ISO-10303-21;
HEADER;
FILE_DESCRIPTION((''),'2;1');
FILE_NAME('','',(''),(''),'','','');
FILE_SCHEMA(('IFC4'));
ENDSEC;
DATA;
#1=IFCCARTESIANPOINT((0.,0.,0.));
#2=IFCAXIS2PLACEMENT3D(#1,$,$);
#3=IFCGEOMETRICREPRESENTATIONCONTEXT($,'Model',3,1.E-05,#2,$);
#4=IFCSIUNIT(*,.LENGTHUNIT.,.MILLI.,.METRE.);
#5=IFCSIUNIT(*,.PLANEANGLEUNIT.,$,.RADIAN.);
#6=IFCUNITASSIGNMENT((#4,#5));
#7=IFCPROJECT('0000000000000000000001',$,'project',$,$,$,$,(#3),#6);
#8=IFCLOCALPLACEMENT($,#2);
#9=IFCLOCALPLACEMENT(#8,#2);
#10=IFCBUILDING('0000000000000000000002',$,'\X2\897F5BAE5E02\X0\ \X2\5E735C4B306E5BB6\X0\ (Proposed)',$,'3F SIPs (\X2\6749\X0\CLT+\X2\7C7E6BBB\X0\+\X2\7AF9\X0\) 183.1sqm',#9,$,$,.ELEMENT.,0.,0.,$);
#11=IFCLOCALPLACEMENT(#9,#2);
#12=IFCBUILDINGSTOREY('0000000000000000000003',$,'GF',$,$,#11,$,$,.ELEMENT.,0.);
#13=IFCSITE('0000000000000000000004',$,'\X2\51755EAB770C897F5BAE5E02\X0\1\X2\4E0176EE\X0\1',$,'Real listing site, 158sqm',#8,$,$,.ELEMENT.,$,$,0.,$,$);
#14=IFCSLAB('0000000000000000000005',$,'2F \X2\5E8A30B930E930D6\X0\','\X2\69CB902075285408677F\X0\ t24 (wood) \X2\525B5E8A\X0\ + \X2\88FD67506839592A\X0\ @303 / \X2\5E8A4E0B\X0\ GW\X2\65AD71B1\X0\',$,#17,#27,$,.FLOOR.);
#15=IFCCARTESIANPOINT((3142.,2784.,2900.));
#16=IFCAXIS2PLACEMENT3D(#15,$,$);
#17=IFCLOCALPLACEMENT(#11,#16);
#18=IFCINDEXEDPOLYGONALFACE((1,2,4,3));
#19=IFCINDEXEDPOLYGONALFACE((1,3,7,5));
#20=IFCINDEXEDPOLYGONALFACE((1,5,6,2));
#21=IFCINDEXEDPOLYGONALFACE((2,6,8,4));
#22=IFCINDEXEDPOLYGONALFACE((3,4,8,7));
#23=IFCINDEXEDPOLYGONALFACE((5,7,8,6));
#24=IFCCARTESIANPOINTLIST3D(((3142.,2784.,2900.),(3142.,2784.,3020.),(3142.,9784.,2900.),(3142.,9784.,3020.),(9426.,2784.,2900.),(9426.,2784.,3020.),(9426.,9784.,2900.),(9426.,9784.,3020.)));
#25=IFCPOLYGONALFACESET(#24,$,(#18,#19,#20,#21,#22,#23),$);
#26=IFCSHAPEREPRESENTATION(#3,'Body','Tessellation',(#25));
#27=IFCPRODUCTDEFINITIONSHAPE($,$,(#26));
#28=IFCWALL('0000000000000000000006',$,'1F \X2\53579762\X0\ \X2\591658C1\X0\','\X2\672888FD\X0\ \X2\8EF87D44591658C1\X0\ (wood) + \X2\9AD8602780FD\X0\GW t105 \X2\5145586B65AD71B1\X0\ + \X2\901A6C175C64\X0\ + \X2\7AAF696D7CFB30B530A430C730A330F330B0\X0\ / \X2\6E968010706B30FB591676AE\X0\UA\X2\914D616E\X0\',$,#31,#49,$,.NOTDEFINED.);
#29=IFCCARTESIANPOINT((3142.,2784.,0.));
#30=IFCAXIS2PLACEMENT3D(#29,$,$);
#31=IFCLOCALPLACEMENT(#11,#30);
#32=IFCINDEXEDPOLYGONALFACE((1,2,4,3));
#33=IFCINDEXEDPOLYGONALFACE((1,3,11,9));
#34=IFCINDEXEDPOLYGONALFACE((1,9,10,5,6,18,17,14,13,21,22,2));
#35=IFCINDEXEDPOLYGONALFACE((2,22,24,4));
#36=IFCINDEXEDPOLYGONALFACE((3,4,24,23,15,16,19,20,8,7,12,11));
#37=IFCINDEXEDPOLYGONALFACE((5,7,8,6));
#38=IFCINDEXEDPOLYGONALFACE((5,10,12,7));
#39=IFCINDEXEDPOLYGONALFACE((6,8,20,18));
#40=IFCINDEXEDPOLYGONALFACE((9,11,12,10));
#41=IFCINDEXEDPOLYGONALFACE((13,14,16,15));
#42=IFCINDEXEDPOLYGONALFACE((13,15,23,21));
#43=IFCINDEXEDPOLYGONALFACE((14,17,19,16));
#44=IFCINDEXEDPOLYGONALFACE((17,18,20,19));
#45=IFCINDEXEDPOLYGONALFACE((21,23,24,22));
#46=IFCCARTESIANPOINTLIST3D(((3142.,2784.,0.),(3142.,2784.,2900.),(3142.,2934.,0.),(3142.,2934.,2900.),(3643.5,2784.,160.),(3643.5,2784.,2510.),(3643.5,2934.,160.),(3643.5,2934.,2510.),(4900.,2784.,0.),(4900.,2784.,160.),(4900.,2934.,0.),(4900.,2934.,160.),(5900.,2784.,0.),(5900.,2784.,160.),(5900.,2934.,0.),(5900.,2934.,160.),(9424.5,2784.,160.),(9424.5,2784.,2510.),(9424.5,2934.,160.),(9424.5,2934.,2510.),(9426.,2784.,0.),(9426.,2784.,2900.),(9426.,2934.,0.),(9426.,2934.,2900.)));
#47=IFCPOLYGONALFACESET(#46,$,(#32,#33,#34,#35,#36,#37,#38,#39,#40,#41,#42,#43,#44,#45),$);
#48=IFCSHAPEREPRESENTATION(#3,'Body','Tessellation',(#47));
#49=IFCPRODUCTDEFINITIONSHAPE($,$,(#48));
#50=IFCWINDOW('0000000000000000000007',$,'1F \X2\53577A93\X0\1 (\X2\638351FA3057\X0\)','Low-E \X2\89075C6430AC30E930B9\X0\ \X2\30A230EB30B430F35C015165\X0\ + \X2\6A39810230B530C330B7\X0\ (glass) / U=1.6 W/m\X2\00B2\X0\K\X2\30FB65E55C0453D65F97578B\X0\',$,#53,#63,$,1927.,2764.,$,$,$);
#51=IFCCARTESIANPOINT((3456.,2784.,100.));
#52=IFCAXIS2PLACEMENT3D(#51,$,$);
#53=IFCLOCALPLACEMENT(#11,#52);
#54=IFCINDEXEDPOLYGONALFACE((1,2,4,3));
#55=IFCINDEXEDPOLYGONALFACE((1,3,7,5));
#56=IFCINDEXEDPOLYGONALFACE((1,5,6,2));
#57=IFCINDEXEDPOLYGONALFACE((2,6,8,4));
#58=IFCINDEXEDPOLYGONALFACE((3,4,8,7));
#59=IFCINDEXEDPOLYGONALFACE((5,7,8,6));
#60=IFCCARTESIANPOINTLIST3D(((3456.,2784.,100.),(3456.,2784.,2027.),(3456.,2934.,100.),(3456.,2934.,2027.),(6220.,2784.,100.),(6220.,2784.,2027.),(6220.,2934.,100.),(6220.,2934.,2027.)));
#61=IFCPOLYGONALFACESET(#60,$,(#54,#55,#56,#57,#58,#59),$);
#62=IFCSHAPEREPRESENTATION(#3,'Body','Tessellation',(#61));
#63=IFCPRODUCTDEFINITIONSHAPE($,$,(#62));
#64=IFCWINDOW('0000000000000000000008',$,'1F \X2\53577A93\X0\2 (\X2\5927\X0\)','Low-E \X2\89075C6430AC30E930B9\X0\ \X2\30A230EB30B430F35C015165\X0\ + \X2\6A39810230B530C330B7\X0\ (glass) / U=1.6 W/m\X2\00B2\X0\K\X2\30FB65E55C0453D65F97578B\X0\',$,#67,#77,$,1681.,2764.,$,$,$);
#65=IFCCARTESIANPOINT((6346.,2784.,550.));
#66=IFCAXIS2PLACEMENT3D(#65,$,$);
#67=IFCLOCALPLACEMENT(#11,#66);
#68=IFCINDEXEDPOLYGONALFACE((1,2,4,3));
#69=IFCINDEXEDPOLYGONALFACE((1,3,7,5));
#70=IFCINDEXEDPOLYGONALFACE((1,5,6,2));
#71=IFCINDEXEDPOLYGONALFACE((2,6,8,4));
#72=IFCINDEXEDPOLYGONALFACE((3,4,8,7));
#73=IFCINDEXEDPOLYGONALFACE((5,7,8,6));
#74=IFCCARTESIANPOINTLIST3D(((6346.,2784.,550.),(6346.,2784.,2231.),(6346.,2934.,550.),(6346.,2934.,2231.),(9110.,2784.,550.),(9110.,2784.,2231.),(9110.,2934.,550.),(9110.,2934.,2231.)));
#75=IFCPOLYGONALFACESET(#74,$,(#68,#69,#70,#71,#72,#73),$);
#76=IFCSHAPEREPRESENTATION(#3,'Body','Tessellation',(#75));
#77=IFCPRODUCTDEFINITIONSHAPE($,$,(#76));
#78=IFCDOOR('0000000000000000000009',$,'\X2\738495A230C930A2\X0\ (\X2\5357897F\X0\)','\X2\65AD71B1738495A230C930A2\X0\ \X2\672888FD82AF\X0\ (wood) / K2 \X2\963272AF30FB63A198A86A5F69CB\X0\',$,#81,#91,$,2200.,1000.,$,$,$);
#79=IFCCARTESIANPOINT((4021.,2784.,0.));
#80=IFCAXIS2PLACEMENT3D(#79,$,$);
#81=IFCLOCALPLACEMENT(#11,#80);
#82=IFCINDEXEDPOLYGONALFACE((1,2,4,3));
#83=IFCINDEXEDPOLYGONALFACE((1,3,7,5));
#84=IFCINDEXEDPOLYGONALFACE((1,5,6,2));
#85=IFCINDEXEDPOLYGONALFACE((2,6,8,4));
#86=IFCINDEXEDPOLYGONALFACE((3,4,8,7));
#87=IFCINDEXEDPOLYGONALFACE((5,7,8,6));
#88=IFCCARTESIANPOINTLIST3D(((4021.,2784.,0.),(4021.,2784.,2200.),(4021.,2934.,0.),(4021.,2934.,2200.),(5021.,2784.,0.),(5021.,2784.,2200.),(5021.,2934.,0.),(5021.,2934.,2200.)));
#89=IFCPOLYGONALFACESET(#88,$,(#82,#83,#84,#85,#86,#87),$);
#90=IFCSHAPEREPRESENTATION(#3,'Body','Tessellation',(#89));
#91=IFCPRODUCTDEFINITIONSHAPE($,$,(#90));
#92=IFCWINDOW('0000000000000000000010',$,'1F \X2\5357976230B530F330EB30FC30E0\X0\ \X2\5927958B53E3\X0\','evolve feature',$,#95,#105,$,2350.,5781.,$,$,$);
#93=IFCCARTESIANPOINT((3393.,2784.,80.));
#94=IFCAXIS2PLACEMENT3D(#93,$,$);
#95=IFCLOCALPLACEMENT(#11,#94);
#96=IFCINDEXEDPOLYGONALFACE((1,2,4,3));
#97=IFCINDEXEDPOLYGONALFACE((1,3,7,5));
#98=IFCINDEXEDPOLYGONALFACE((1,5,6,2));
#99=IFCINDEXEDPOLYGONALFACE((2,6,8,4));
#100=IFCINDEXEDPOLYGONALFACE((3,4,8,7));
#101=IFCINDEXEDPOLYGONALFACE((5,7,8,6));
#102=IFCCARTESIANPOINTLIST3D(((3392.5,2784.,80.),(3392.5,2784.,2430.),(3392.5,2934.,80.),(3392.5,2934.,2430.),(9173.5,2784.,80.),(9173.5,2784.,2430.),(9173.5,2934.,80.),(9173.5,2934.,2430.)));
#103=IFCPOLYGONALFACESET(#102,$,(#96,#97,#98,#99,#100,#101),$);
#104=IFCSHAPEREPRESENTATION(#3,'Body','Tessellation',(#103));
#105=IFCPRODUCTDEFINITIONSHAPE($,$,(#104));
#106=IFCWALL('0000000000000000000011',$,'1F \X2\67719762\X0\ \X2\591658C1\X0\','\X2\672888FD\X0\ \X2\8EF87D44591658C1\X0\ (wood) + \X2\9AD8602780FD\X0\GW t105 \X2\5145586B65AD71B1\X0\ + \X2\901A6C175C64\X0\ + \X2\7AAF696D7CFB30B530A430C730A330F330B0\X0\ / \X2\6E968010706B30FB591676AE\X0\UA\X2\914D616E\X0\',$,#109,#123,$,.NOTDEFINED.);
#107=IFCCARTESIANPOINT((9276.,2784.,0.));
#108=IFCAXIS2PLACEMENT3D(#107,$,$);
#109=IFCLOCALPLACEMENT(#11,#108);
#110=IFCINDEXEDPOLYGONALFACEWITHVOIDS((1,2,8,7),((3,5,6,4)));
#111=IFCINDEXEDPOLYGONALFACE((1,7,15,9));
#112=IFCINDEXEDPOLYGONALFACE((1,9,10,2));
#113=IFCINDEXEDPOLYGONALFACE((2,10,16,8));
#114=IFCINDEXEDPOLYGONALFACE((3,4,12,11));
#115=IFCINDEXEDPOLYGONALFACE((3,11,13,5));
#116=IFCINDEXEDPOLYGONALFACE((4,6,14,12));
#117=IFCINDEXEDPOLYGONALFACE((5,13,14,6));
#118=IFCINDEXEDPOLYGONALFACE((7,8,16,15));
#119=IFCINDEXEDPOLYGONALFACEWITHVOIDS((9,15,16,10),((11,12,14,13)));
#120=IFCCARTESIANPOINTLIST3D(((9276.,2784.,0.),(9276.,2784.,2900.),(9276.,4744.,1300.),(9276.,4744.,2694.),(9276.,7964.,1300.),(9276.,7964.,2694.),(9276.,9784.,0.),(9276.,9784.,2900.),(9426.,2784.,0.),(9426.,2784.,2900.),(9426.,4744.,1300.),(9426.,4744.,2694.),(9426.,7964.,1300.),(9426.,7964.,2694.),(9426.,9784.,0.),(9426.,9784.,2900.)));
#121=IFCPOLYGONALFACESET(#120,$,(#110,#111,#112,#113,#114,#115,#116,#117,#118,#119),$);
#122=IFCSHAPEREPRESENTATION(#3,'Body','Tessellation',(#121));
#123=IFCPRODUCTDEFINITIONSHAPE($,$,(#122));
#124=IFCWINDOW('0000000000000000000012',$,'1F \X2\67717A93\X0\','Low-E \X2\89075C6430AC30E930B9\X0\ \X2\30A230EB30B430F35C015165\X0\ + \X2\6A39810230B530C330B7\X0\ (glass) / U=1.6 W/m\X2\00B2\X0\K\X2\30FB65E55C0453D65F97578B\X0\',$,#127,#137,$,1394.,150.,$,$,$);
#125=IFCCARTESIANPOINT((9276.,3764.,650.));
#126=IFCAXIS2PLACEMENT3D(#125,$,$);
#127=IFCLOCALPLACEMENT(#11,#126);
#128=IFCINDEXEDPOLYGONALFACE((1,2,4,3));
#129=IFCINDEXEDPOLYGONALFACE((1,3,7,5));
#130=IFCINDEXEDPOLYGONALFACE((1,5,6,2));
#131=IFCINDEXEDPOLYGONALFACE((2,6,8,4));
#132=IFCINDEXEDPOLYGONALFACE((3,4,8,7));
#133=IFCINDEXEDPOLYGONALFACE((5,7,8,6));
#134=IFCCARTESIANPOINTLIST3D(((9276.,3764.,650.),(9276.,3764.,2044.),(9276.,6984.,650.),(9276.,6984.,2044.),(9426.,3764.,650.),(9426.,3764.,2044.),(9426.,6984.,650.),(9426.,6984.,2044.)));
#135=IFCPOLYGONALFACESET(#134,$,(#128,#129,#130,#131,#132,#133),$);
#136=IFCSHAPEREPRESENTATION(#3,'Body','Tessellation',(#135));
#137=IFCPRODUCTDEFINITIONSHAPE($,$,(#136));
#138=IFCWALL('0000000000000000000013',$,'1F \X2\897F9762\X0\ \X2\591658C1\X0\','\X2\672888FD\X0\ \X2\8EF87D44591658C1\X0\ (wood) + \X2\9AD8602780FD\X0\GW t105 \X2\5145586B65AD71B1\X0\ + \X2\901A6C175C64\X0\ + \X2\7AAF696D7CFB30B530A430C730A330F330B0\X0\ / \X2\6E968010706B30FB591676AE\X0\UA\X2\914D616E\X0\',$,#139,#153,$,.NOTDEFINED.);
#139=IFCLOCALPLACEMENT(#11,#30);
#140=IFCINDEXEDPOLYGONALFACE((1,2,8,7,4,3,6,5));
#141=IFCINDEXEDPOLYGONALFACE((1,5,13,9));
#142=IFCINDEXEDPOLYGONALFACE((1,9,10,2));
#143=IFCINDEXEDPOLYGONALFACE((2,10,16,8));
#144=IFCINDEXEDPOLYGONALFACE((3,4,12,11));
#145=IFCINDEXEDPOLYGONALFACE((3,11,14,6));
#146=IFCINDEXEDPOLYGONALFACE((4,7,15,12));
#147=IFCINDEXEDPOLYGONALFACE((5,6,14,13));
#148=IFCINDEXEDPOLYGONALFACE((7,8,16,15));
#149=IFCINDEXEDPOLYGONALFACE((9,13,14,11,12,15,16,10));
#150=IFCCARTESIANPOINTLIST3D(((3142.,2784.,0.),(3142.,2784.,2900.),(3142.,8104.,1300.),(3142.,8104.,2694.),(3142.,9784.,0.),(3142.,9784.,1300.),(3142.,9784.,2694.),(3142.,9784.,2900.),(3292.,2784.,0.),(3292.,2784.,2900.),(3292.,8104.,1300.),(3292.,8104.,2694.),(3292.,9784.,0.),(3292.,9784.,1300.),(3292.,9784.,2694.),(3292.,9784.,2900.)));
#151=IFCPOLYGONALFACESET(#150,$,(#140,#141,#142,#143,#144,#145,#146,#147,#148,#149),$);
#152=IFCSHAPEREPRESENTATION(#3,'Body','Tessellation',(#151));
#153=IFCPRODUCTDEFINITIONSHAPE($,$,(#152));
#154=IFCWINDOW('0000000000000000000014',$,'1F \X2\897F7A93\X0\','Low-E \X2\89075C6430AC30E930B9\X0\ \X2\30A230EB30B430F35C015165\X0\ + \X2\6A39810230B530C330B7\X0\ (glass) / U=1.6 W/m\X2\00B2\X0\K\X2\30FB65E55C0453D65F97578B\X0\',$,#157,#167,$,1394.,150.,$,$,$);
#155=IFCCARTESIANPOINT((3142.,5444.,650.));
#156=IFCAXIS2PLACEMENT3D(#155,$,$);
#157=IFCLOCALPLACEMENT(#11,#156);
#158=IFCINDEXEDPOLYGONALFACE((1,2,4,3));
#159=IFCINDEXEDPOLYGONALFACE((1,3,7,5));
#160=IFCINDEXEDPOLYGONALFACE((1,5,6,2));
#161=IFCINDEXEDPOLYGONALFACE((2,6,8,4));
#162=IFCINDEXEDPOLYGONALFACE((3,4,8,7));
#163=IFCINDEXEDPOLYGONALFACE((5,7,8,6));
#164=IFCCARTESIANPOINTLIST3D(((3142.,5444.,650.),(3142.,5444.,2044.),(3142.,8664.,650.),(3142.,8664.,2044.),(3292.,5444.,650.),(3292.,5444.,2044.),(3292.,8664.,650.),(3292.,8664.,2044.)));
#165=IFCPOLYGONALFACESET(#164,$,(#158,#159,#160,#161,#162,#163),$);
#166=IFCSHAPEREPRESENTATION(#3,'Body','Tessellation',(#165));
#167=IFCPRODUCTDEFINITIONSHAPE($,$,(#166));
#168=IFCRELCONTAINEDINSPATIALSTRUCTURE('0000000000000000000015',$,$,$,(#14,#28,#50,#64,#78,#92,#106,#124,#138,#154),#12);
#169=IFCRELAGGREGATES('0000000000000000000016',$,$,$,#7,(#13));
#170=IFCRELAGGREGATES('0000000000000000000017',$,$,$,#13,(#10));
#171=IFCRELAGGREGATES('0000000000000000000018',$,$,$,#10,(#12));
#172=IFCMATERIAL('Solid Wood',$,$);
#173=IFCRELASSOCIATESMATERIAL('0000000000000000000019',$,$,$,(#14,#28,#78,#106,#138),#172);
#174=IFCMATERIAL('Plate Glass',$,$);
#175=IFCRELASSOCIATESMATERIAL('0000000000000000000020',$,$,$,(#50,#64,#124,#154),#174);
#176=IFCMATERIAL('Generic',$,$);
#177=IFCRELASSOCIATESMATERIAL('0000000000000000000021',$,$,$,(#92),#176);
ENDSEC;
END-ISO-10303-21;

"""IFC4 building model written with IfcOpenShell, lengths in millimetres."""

from ifc_helpers import new_model, si_unit, frame, frame_2d, origin, place, context, project, spatial, rectangle, extrude, material, element, fill, save


model = new_model("IFC4")

# Units and contexts
model_context = context("Model", 3, precision=1e-05, world=origin())
ifc_project = project(units=[si_unit("LENGTHUNIT", "METRE", prefix="MILLI"), si_unit("PLANEANGLEUNIT", "RADIAN")], contexts=[model_context])

# Site, building, storey
site_placement = place(None, origin())
site = spatial("IfcSite", under=ifc_project, at=site_placement, Name="兵庫県西宮市1丁目1", ObjectType="Real listing site, 158sqm", CompositionType="ELEMENT", RefElevation=0.0)
building_placement = place(site_placement, origin())
building = spatial("IfcBuilding", under=site, at=building_placement, Name="西宮市 平屋の家 (Proposed)", ObjectType="3F SIPs (杉CLT+籾殻+竹) 183.1sqm", CompositionType="ELEMENT", ElevationOfRefHeight=0.0, ElevationOfTerrain=0.0)
storey_placement = place(building_placement, origin())
storey = spatial("IfcBuildingStorey", under=building, at=storey_placement, Name="GF", CompositionType="ELEMENT", Elevation=0.0)

# Slab
ifc_material_1 = material(Name="Solid Wood")
slab_1_placement = place(storey_placement, frame((3142.0, 2784.0, 2900.0)))
element("IfcSlab", 1, at=slab_1_placement, inside=storey, material=ifc_material_1, Name="2F 床スラブ", Description="構造用合板 t24 (wood) 剛床 + 製材根太 @303 / 床下 GW断熱", PredefinedType="FLOOR", context=model_context, shape_type="SweptSolid", body=[
    extrude(rectangle(XDim=6284.0, YDim=7000.0, at=frame_2d((3142.0, 3500.0))), frame((3142.0, 2784.0, 2900.0)), (0.0, 0.0, 1.0), 120.0),
])

# Wall, openings, windows, door
wall_1_placement = place(storey_placement, frame((3142.0, 2784.0, 0.0)))
wall_1 = element("IfcWall", 2, at=wall_1_placement, inside=storey, material=ifc_material_1, Name="1F 南面 外壁", Description="木製 軸組外壁 (wood) + 高性能GW t105 充填断熱 + 通気層 + 窯業系サイディング / 準耐火・外皮UA配慮", PredefinedType="NOTDEFINED", context=model_context, shape_type="SweptSolid", body=[
    extrude(rectangle(XDim=6284.0, YDim=150.0, at=frame_2d((3142.0, 75.0))), frame((3142.0, 2784.0, 0.0)), (0.0, 0.0, 1.0), 2900.0),
])
opening_1_placement = place(storey_placement, frame((3456.0, 2784.0, 100.0)))
opening_1 = element("IfcOpeningElement", 3, at=opening_1_placement, cuts=wall_1, PredefinedType="NOTDEFINED", context=model_context, shape_type="SweptSolid", body=[
    extrude(rectangle(XDim=2764.0, YDim=150.0, at=frame_2d((1382.0, 75.0))), frame((3456.0, 2784.0, 100.0)), (0.0, 0.0, 1.0), 1927.0),
])
opening_2_placement = place(storey_placement, frame((6346.0, 2784.0, 550.0)))
opening_2 = element("IfcOpeningElement", 4, at=opening_2_placement, cuts=wall_1, PredefinedType="NOTDEFINED", context=model_context, shape_type="SweptSolid", body=[
    extrude(rectangle(XDim=2764.0, YDim=150.0, at=frame_2d((1382.0, 75.0))), frame((6346.0, 2784.0, 550.0)), (0.0, 0.0, 1.0), 1681.0),
])
opening_3_placement = place(storey_placement, frame((4021.0, 2784.0, 0.0)))
opening_3 = element("IfcOpeningElement", 5, at=opening_3_placement, cuts=wall_1, PredefinedType="NOTDEFINED", context=model_context, shape_type="SweptSolid", body=[
    extrude(rectangle(XDim=1000.0, YDim=150.0, at=frame_2d((500.0, 75.0))), frame((4021.0, 2784.0, 0.0)), (0.0, 0.0, 1.0), 2200.0),
])
opening_4_placement = place(storey_placement, frame((3393.0, 2784.0, 80.0)))
opening_4 = element("IfcOpeningElement", 6, at=opening_4_placement, cuts=wall_1, PredefinedType="NOTDEFINED", context=model_context, shape_type="SweptSolid", body=[
    extrude(rectangle(XDim=5781.0, YDim=150.0, at=frame_2d((2890.0, 75.0))), frame((3393.0, 2784.0, 80.0)), (0.0, 0.0, 1.0), 2350.0),
])
ifc_material_2 = material(Name="Plate Glass")
window_1_placement = place(storey_placement, frame((3456.0, 2784.0, 100.0)))
window_1 = element("IfcWindow", 7, at=window_1_placement, inside=storey, material=ifc_material_2, Name="1F 南窓1 (掃出し)", Description="Low-E 複層ガラス アルゴン封入 + 樹脂サッシ (glass) / U=1.6 W/m²K・日射取得型", OverallHeight=1927.0, OverallWidth=2764.0, context=model_context, shape_type="SweptSolid", body=[
    extrude(rectangle(XDim=2764.0, YDim=150.0, at=frame_2d((1382.0, 75.0))), frame((3456.0, 2784.0, 100.0)), (0.0, 0.0, 1.0), 1927.0),
])
fill(opening_1, window_1)
window_2_placement = place(storey_placement, frame((6346.0, 2784.0, 550.0)))
window_2 = element("IfcWindow", 8, at=window_2_placement, inside=storey, material=ifc_material_2, Name="1F 南窓2 (大)", Description="Low-E 複層ガラス アルゴン封入 + 樹脂サッシ (glass) / U=1.6 W/m²K・日射取得型", OverallHeight=1681.0, OverallWidth=2764.0, context=model_context, shape_type="SweptSolid", body=[
    extrude(rectangle(XDim=2764.0, YDim=150.0, at=frame_2d((1382.0, 75.0))), frame((6346.0, 2784.0, 550.0)), (0.0, 0.0, 1.0), 1681.0),
])
fill(opening_2, window_2)
door_placement = place(storey_placement, frame((4021.0, 2784.0, 0.0)))
door = element("IfcDoor", 9, at=door_placement, inside=storey, material=ifc_material_1, Name="玄関ドア (南西)", Description="断熱玄関ドア 木製芯 (wood) / K2 防犯・採風機構", OverallHeight=2200.0, OverallWidth=1000.0, context=model_context, shape_type="SweptSolid", body=[
    extrude(rectangle(XDim=1000.0, YDim=150.0, at=frame_2d((500.0, 75.0))), frame((4021.0, 2784.0, 0.0)), (0.0, 0.0, 1.0), 2200.0),
])
fill(opening_3, door)
ifc_material_3 = material(Name="Generic")
window_3_placement = place(storey_placement, frame((3393.0, 2784.0, 80.0)))
window_3 = element("IfcWindow", 10, at=window_3_placement, inside=storey, material=ifc_material_3, Name="1F 南面サンルーム 大開口", Description="evolve feature", OverallHeight=2350.0, OverallWidth=5781.0, context=model_context, shape_type="SweptSolid", body=[
    extrude(rectangle(XDim=5781.0, YDim=150.0, at=frame_2d((2890.0, 75.0))), frame((3393.0, 2784.0, 80.0)), (0.0, 0.0, 1.0), 2350.0),
])
fill(opening_4, window_3)

# Walls, openings, windows
wall_2_placement = place(storey_placement, frame((9276.0, 2784.0, 0.0)))
wall_2 = element("IfcWall", 11, at=wall_2_placement, inside=storey, material=ifc_material_1, Name="1F 東面 外壁", Description="木製 軸組外壁 (wood) + 高性能GW t105 充填断熱 + 通気層 + 窯業系サイディング / 準耐火・外皮UA配慮", PredefinedType="NOTDEFINED", context=model_context, shape_type="SweptSolid", body=[
    extrude(rectangle(XDim=150.0, YDim=7000.0, at=frame_2d((75.0, 3500.0))), frame((9276.0, 2784.0, 0.0)), (0.0, 0.0, 1.0), 2900.0),
])
opening_5_placement = place(storey_placement, frame((9276.0, 3764.0, 650.0)))
opening_5 = element("IfcOpeningElement", 12, at=opening_5_placement, cuts=wall_2, PredefinedType="NOTDEFINED", context=model_context, shape_type="SweptSolid", body=[
    extrude(rectangle(XDim=150.0, YDim=3220.0, at=frame_2d((75.0, 1610.0))), frame((9276.0, 3764.0, 650.0)), (0.0, 0.0, 1.0), 1394.0),
])
window_4_placement = place(storey_placement, frame((9276.0, 3764.0, 650.0)))
window_4 = element("IfcWindow", 13, at=window_4_placement, inside=storey, material=ifc_material_2, Name="1F 東窓", Description="Low-E 複層ガラス アルゴン封入 + 樹脂サッシ (glass) / U=1.6 W/m²K・日射取得型", OverallHeight=1394.0, OverallWidth=150.0, context=model_context, shape_type="SweptSolid", body=[
    extrude(rectangle(XDim=150.0, YDim=3220.0, at=frame_2d((75.0, 1610.0))), frame((9276.0, 3764.0, 650.0)), (0.0, 0.0, 1.0), 1394.0),
])
fill(opening_5, window_4)
wall_3_placement = place(storey_placement, frame((3142.0, 2784.0, 0.0)))
wall_3 = element("IfcWall", 14, at=wall_3_placement, inside=storey, material=ifc_material_1, Name="1F 西面 外壁", Description="木製 軸組外壁 (wood) + 高性能GW t105 充填断熱 + 通気層 + 窯業系サイディング / 準耐火・外皮UA配慮", PredefinedType="NOTDEFINED", context=model_context, shape_type="SweptSolid", body=[
    extrude(rectangle(XDim=150.0, YDim=7000.0, at=frame_2d((75.0, 3500.0))), frame((3142.0, 2784.0, 0.0)), (0.0, 0.0, 1.0), 2900.0),
])
opening_6_placement = place(storey_placement, frame((3142.0, 5444.0, 650.0)))
opening_6 = element("IfcOpeningElement", 15, at=opening_6_placement, cuts=wall_3, PredefinedType="NOTDEFINED", context=model_context, shape_type="SweptSolid", body=[
    extrude(rectangle(XDim=150.0, YDim=3220.0, at=frame_2d((75.0, 1610.0))), frame((3142.0, 5444.0, 650.0)), (0.0, 0.0, 1.0), 1394.0),
])
window_5_placement = place(storey_placement, frame((3142.0, 5444.0, 650.0)))
window_5 = element("IfcWindow", 16, at=window_5_placement, inside=storey, material=ifc_material_2, Name="1F 西窓", Description="Low-E 複層ガラス アルゴン封入 + 樹脂サッシ (glass) / U=1.6 W/m²K・日射取得型", OverallHeight=1394.0, OverallWidth=150.0, context=model_context, shape_type="SweptSolid", body=[
    extrude(rectangle(XDim=150.0, YDim=3220.0, at=frame_2d((75.0, 1610.0))), frame((3142.0, 5444.0, 650.0)), (0.0, 0.0, 1.0), 1394.0),
])
fill(opening_6, window_5)

save(model, "model.ifc")
